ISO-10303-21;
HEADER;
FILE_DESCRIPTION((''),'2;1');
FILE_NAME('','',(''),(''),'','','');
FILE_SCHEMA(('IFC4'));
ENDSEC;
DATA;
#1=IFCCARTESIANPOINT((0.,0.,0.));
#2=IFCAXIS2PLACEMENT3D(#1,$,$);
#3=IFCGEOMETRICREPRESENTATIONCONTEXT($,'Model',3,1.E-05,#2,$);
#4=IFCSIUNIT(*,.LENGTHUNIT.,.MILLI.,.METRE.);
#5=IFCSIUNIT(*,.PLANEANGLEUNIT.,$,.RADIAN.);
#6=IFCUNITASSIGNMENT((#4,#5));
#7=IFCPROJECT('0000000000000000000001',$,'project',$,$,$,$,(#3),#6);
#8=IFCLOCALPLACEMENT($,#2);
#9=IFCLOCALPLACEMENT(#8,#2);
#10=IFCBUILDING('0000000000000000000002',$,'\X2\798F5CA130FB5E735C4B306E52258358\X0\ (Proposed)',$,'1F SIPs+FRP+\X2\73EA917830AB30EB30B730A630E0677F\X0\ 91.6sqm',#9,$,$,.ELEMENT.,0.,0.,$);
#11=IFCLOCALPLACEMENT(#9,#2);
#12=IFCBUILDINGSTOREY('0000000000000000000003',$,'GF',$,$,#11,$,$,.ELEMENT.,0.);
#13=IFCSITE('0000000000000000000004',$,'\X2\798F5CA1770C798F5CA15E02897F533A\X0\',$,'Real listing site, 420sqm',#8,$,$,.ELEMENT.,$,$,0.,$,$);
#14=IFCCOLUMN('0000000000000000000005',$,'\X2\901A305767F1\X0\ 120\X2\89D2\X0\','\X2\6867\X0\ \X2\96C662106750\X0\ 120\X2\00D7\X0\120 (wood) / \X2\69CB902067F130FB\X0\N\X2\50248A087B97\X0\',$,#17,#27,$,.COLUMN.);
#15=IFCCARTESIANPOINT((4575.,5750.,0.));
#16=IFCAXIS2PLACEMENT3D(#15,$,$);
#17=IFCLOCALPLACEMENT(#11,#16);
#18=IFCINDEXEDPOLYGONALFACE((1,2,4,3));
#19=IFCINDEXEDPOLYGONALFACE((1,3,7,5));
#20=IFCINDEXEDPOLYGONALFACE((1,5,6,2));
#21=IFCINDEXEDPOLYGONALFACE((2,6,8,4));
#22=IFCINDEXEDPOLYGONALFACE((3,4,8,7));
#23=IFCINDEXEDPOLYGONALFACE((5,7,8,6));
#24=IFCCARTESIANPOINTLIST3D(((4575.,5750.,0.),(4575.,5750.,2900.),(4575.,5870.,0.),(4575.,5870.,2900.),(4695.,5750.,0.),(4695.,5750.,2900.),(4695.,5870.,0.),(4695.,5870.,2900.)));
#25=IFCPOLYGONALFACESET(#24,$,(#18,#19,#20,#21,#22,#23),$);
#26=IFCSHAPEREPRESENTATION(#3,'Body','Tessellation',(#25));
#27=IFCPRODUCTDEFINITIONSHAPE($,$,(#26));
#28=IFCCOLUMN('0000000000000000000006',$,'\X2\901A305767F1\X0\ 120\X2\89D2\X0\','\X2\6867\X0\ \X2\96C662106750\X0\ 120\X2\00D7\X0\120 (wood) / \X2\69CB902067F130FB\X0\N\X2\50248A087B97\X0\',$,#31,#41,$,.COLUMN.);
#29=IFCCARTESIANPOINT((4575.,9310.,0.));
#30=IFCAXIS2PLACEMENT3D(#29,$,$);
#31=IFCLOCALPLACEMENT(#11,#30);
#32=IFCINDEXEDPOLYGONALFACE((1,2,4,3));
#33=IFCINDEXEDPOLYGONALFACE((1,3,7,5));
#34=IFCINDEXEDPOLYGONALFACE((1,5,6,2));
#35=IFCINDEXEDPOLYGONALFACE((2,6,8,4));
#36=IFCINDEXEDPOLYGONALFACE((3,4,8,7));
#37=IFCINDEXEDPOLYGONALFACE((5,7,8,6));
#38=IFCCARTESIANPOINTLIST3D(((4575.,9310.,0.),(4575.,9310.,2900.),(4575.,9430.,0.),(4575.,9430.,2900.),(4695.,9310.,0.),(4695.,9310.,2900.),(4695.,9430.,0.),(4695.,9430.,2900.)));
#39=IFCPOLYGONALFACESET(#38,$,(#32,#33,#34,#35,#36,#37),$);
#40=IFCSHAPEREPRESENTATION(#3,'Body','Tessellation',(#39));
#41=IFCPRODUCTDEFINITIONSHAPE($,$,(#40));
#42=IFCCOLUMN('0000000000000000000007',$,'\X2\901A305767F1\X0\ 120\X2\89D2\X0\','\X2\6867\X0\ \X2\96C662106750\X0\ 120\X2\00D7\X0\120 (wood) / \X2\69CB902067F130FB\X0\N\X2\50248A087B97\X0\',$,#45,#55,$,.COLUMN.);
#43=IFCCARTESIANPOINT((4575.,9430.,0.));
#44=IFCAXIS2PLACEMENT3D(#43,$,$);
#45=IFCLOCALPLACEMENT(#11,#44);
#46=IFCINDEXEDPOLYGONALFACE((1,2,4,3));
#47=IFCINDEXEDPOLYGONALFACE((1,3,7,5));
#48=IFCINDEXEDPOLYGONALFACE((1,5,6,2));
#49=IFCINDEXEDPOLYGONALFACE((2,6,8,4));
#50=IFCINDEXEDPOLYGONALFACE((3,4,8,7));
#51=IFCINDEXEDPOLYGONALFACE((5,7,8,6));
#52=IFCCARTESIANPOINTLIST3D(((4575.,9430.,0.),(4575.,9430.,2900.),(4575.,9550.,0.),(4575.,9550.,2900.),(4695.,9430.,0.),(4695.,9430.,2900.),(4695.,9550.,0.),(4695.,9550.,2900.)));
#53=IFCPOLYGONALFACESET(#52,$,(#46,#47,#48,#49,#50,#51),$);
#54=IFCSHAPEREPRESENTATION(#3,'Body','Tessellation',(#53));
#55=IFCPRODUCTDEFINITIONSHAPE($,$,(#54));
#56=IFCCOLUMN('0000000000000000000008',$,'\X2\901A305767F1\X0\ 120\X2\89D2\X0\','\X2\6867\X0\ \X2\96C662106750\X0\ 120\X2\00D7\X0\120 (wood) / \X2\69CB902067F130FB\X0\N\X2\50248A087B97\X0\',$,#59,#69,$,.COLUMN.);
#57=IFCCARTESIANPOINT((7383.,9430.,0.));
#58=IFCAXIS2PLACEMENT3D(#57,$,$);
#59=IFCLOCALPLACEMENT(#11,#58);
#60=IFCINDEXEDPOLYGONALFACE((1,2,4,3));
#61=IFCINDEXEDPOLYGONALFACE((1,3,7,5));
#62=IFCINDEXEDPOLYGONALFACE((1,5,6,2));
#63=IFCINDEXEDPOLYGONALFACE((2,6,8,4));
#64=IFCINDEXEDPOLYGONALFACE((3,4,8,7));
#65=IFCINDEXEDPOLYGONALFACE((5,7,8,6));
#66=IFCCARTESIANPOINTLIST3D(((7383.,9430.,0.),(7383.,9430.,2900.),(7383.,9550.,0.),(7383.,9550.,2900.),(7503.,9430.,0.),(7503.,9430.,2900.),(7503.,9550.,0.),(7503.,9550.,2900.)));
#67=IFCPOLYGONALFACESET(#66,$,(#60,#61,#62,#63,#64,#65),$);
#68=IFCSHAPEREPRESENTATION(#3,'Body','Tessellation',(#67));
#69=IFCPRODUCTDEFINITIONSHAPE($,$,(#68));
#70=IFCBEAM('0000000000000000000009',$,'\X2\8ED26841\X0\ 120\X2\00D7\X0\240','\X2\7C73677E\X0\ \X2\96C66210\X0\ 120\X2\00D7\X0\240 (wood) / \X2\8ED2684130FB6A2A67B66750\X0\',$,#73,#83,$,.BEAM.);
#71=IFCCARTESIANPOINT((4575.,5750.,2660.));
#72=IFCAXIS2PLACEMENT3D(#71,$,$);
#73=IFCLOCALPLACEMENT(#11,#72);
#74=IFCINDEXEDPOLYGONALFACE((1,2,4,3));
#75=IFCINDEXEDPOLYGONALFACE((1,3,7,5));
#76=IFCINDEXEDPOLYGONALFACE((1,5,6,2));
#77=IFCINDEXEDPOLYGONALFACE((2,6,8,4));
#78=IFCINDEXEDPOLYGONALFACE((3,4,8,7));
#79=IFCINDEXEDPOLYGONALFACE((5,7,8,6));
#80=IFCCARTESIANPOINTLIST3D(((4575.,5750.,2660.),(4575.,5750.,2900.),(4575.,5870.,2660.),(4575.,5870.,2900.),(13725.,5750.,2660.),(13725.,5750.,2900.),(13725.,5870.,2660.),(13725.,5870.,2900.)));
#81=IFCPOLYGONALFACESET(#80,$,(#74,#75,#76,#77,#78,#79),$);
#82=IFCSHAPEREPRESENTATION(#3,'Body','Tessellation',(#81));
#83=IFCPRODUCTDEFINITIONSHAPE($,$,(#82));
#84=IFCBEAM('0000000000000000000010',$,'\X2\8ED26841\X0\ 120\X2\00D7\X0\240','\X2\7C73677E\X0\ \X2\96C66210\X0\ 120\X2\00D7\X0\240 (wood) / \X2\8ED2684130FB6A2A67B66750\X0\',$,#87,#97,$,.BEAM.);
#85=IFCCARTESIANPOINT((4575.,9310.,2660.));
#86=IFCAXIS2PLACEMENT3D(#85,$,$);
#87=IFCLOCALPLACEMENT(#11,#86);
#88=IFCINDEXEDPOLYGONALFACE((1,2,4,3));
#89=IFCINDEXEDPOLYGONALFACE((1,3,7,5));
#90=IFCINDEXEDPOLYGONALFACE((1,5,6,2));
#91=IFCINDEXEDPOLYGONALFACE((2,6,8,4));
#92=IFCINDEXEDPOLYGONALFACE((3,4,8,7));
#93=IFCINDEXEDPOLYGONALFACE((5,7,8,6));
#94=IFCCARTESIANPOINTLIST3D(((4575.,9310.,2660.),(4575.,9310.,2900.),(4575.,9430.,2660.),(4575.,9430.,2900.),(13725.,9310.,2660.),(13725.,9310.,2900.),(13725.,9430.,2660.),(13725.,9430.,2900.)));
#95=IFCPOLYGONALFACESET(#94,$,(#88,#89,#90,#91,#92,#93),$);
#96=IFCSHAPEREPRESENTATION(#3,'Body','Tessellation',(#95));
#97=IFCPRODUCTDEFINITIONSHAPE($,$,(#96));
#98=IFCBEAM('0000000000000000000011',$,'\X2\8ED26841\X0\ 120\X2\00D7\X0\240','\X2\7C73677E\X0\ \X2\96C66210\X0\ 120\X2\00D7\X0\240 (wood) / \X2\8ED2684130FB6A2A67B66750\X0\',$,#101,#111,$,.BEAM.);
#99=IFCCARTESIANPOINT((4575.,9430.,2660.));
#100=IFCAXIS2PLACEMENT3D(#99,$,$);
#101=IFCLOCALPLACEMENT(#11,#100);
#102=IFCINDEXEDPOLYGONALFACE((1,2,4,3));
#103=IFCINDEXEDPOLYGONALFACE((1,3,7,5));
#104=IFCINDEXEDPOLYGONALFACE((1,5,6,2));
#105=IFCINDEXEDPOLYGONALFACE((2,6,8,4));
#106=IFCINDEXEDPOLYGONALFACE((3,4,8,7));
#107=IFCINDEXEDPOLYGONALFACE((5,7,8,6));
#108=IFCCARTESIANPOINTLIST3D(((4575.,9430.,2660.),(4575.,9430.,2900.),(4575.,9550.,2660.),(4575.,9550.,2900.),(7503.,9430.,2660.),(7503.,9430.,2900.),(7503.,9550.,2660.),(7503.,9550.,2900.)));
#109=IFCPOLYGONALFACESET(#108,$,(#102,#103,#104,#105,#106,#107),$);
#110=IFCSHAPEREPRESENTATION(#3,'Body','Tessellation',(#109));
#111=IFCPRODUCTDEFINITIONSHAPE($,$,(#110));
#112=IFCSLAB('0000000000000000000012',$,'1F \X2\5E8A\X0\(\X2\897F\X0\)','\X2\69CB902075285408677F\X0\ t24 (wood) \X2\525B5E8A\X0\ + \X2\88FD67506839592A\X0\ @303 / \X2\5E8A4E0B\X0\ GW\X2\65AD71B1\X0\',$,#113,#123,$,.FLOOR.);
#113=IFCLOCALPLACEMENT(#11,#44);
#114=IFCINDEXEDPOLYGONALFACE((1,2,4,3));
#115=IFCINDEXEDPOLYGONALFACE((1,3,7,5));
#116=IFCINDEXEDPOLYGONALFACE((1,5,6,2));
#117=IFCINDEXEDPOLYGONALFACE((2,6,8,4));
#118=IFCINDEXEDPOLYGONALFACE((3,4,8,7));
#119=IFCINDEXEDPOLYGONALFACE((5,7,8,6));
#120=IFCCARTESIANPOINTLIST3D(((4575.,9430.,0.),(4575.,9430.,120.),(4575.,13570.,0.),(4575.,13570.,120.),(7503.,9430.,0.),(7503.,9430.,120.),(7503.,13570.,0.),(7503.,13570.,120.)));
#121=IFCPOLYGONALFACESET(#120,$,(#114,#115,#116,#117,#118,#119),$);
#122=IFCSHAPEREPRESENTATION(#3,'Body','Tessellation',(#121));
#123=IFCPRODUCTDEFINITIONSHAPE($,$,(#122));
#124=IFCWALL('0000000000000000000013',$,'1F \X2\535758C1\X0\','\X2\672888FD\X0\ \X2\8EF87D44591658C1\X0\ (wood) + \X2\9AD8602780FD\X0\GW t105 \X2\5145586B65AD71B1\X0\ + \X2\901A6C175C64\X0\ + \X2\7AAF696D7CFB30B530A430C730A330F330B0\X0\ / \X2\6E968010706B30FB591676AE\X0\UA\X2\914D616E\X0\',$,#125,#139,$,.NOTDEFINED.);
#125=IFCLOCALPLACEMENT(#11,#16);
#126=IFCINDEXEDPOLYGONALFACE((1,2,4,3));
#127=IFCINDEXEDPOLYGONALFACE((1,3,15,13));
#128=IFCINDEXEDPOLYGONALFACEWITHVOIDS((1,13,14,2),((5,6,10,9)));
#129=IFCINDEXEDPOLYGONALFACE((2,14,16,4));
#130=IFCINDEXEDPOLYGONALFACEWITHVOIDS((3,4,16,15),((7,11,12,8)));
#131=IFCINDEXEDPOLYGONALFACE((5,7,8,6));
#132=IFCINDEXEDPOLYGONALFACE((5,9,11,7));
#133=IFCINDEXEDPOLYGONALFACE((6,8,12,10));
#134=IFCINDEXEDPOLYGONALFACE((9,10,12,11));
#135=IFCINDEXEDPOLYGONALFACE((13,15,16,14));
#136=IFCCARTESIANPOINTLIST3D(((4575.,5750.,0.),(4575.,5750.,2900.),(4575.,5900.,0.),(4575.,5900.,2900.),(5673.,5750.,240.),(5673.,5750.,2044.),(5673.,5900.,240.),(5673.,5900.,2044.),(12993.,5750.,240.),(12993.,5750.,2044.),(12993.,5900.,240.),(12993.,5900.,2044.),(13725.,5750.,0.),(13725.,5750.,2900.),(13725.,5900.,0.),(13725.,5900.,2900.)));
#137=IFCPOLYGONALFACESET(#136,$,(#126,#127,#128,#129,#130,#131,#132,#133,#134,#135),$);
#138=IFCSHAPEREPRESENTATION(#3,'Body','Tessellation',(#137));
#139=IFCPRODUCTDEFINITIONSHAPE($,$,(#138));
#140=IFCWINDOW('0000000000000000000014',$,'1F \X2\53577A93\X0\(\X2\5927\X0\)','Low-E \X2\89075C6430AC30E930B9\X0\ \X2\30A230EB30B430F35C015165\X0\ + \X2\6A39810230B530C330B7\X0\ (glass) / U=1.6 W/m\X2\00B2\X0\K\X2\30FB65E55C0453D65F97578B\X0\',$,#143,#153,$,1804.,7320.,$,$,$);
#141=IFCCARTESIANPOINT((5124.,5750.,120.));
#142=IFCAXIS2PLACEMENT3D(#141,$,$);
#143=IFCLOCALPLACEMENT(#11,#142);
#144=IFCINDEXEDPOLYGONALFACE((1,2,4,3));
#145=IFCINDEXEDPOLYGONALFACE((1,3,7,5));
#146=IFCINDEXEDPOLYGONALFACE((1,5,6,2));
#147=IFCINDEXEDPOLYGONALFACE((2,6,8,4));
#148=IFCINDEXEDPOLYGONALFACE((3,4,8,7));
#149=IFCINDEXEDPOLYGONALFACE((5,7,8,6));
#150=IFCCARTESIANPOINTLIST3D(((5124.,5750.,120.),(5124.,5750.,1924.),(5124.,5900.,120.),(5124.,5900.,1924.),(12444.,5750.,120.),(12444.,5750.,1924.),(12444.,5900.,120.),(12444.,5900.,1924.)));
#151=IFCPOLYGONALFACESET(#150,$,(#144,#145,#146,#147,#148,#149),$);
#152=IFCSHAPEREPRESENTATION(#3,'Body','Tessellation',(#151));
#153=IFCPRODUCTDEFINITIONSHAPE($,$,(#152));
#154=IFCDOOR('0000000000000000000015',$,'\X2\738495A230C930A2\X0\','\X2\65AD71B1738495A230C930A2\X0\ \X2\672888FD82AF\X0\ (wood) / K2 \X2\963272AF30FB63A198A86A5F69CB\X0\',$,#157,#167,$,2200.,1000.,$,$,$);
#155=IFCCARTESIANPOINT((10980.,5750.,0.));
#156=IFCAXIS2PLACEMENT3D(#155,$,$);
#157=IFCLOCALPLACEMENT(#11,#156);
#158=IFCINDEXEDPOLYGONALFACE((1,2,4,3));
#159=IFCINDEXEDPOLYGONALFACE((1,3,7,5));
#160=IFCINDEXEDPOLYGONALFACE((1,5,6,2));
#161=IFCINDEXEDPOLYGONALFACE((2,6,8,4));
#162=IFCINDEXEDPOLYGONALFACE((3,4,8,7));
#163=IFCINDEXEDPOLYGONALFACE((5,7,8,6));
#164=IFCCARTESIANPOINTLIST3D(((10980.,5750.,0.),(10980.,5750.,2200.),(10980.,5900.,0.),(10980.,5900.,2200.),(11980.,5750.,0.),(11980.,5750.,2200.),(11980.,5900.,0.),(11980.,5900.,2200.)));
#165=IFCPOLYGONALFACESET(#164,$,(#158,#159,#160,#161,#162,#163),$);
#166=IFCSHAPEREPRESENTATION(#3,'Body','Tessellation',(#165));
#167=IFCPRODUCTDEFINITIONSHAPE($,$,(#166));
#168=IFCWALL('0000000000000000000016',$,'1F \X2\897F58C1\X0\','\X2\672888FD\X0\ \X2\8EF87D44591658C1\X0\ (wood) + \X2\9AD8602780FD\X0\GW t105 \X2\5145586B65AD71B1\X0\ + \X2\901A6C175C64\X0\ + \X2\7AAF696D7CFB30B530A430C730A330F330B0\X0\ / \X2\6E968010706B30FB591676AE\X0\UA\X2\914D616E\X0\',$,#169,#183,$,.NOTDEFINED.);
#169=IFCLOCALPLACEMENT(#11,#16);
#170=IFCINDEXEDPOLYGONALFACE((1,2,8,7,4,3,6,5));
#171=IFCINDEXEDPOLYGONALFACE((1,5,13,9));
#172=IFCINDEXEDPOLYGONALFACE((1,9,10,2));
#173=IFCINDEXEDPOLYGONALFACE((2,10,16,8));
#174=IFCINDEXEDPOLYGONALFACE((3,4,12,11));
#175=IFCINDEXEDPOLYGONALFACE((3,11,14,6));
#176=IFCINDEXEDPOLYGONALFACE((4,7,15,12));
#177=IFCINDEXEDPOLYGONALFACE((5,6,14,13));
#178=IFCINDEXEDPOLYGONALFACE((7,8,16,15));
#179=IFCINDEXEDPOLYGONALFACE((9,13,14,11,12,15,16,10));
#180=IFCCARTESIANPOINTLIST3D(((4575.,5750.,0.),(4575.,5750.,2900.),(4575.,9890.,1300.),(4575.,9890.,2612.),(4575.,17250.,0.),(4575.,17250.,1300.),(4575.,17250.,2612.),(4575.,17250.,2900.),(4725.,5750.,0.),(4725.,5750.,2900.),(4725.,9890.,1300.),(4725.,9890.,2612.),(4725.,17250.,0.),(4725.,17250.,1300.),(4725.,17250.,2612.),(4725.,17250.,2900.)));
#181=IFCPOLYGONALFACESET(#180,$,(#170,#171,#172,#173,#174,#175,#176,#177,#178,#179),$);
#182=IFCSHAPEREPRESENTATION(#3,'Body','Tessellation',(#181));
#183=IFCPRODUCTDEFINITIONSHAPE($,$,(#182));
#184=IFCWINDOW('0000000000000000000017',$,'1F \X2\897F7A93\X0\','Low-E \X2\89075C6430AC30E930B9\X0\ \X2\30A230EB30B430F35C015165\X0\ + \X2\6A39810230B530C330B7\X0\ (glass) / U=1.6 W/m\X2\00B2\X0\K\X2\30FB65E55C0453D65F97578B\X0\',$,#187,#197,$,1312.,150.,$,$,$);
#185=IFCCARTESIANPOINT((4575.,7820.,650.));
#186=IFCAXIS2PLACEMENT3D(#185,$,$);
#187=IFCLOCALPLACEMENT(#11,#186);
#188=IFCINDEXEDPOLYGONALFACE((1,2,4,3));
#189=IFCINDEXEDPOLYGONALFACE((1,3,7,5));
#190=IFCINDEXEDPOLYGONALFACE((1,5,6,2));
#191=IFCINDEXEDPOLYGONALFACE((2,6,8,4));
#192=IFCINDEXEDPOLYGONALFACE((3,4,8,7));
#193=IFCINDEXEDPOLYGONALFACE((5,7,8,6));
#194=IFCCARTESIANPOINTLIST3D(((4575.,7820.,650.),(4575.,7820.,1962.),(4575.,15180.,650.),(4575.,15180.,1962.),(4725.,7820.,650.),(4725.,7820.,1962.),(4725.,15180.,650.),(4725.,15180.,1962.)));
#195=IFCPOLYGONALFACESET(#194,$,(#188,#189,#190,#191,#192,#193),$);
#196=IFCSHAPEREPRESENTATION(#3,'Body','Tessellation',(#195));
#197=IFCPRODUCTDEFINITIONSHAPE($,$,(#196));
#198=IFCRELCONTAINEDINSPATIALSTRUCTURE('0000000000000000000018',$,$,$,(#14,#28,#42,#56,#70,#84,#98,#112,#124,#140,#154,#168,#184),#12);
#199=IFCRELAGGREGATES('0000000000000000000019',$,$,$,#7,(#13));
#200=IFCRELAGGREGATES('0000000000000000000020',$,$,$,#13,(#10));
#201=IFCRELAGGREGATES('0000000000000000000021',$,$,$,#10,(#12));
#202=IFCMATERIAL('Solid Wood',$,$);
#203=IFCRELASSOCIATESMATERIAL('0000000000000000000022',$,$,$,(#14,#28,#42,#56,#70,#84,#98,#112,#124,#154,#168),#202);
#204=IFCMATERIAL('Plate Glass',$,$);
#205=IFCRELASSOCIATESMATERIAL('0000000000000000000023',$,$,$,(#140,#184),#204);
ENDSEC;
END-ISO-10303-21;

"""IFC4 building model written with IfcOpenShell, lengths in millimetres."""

from ifc_helpers import new_model, si_unit, frame, frame_2d, origin, place, context, project, spatial, rectangle, extrude, material, element, fill, save


model = new_model("IFC4")

# Units and contexts
model_context = context("Model", 3, precision=1e-05, world=origin())
ifc_project = project(units=[si_unit("LENGTHUNIT", "METRE", prefix="MILLI"), si_unit("PLANEANGLEUNIT", "RADIAN")], contexts=[model_context])

# Site, building, storey
site_placement = place(None, origin())
site = spatial("IfcSite", under=ifc_project, at=site_placement, Name="福岡県福岡市西区", ObjectType="Real listing site, 420sqm", CompositionType="ELEMENT", RefElevation=0.0)
building_placement = place(site_placement, origin())
building = spatial("IfcBuilding", under=site, at=building_placement, Name="福岡・平屋の別荘 (Proposed)", ObjectType="1F SIPs+FRP+珪酸カルシウム板 91.6sqm", CompositionType="ELEMENT", ElevationOfRefHeight=0.0, ElevationOfTerrain=0.0)
storey_placement = place(building_placement, origin())
storey = spatial("IfcBuildingStorey", under=building, at=storey_placement, Name="GF", CompositionType="ELEMENT", Elevation=0.0)

# Columns
ifc_material_1 = material(Name="Solid Wood")
column_1_placement = place(storey_placement, frame((4575.0, 5750.0, 0.0)))
element("IfcColumn", 1, at=column_1_placement, inside=storey, material=ifc_material_1, Name="通し柱 120角", Description="桧 集成材 120×120 (wood) / 構造柱・N値計算", PredefinedType="COLUMN", context=model_context, shape_type="SweptSolid", body=[
    extrude(rectangle(XDim=120.0, YDim=120.0, at=frame_2d((60.0, 60.0))), frame((4575.0, 5750.0, 0.0)), (0.0, 0.0, 1.0), 2900.0),
])
column_2_placement = place(storey_placement, frame((4575.0, 9310.0, 0.0)))
element("IfcColumn", 2, at=column_2_placement, inside=storey, material=ifc_material_1, Name="通し柱 120角", Description="桧 集成材 120×120 (wood) / 構造柱・N値計算", PredefinedType="COLUMN", context=model_context, shape_type="SweptSolid", body=[
    extrude(rectangle(XDim=120.0, YDim=120.0, at=frame_2d((60.0, 60.0))), frame((4575.0, 9310.0, 0.0)), (0.0, 0.0, 1.0), 2900.0),
])
column_3_placement = place(storey_placement, frame((4575.0, 9430.0, 0.0)))
element("IfcColumn", 3, at=column_3_placement, inside=storey, material=ifc_material_1, Name="通し柱 120角", Description="桧 集成材 120×120 (wood) / 構造柱・N値計算", PredefinedType="COLUMN", context=model_context, shape_type="SweptSolid", body=[
    extrude(rectangle(XDim=120.0, YDim=120.0, at=frame_2d((60.0, 60.0))), frame((4575.0, 9430.0, 0.0)), (0.0, 0.0, 1.0), 2900.0),
])
column_4_placement = place(storey_placement, frame((7383.0, 9430.0, 0.0)))
element("IfcColumn", 4, at=column_4_placement, inside=storey, material=ifc_material_1, Name="通し柱 120角", Description="桧 集成材 120×120 (wood) / 構造柱・N値計算", PredefinedType="COLUMN", context=model_context, shape_type="SweptSolid", body=[
    extrude(rectangle(XDim=120.0, YDim=120.0, at=frame_2d((60.0, 60.0))), frame((7383.0, 9430.0, 0.0)), (0.0, 0.0, 1.0), 2900.0),
])

# Beams
beam_1_placement = place(storey_placement, frame((4575.0, 5750.0, 2660.0)))
element("IfcBeam", 5, at=beam_1_placement, inside=storey, material=ifc_material_1, Name="軒桁 120×240", Description="米松 集成 120×240 (wood) / 軒桁・横架材", PredefinedType="BEAM", context=model_context, shape_type="SweptSolid", body=[
    extrude(rectangle(XDim=9150.0, YDim=120.0, at=frame_2d((4575.0, 60.0))), frame((4575.0, 5750.0, 2660.0)), (0.0, 0.0, 1.0), 240.0),
])
beam_2_placement = place(storey_placement, frame((4575.0, 9310.0, 2660.0)))
element("IfcBeam", 6, at=beam_2_placement, inside=storey, material=ifc_material_1, Name="軒桁 120×240", Description="米松 集成 120×240 (wood) / 軒桁・横架材", PredefinedType="BEAM", context=model_context, shape_type="SweptSolid", body=[
    extrude(rectangle(XDim=9150.0, YDim=120.0, at=frame_2d((4575.0, 60.0))), frame((4575.0, 9310.0, 2660.0)), (0.0, 0.0, 1.0), 240.0),
])
beam_3_placement = place(storey_placement, frame((4575.0, 9430.0, 2660.0)))
element("IfcBeam", 7, at=beam_3_placement, inside=storey, material=ifc_material_1, Name="軒桁 120×240", Description="米松 集成 120×240 (wood) / 軒桁・横架材", PredefinedType="BEAM", context=model_context, shape_type="SweptSolid", body=[
    extrude(rectangle(XDim=2928.0, YDim=120.0, at=frame_2d((1464.0, 60.0))), frame((4575.0, 9430.0, 2660.0)), (0.0, 0.0, 1.0), 240.0),
])

# Slab
slab_1_placement = place(storey_placement, frame((4575.0, 9430.0, 0.0)))
element("IfcSlab", 8, at=slab_1_placement, inside=storey, material=ifc_material_1, Name="1F 床(西)", Description="構造用合板 t24 (wood) 剛床 + 製材根太 @303 / 床下 GW断熱", PredefinedType="FLOOR", context=model_context, shape_type="SweptSolid", body=[
    extrude(rectangle(XDim=2928.0, YDim=4140.0, at=frame_2d((1464.0, 2070.0))), frame((4575.0, 9430.0, 0.0)), (0.0, 0.0, 1.0), 120.0),
])

# Wall, openings, window, door
wall_1_placement = place(storey_placement, frame((4575.0, 5750.0, 0.0)))
wall_1 = element("IfcWall", 9, at=wall_1_placement, inside=storey, material=ifc_material_1, Name="1F 南壁", Description="木製 軸組外壁 (wood) + 高性能GW t105 充填断熱 + 通気層 + 窯業系サイディング / 準耐火・外皮UA配慮", PredefinedType="NOTDEFINED", context=model_context, shape_type="SweptSolid", body=[
    extrude(rectangle(XDim=9150.0, YDim=150.0, at=frame_2d((4575.0, 75.0))), frame((4575.0, 5750.0, 0.0)), (0.0, 0.0, 1.0), 2900.0),
])
opening_1_placement = place(storey_placement, frame((5124.0, 5750.0, 120.0)))
opening_1 = element("IfcOpeningElement", 10, at=opening_1_placement, cuts=wall_1, PredefinedType="NOTDEFINED", context=model_context, shape_type="SweptSolid", body=[
    extrude(rectangle(XDim=7320.0, YDim=150.0, at=frame_2d((3660.0, 75.0))), frame((5124.0, 5750.0, 120.0)), (0.0, 0.0, 1.0), 1804.0),
])
opening_2_placement = place(storey_placement, frame((10980.0, 5750.0, 0.0)))
opening_2 = element("IfcOpeningElement", 11, at=opening_2_placement, cuts=wall_1, PredefinedType="NOTDEFINED", context=model_context, shape_type="SweptSolid", body=[
    extrude(rectangle(XDim=1000.0, YDim=150.0, at=frame_2d((500.0, 75.0))), frame((10980.0, 5750.0, 0.0)), (0.0, 0.0, 1.0), 2200.0),
])
ifc_material_2 = material(Name="Plate Glass")
window_1_placement = place(storey_placement, frame((5124.0, 5750.0, 120.0)))
window_1 = element("IfcWindow", 12, at=window_1_placement, inside=storey, material=ifc_material_2, Name="1F 南窓(大)", Description="Low-E 複層ガラス アルゴン封入 + 樹脂サッシ (glass) / U=1.6 W/m²K・日射取得型", OverallHeight=1804.0, OverallWidth=7320.0, context=model_context, shape_type="SweptSolid", body=[
    extrude(rectangle(XDim=7320.0, YDim=150.0, at=frame_2d((3660.0, 75.0))), frame((5124.0, 5750.0, 120.0)), (0.0, 0.0, 1.0), 1804.0),
])
fill(opening_1, window_1)
door_placement = place(storey_placement, frame((10980.0, 5750.0, 0.0)))
door = element("IfcDoor", 13, at=door_placement, inside=storey, material=ifc_material_1, Name="玄関ドア", Description="断熱玄関ドア 木製芯 (wood) / K2 防犯・採風機構", OverallHeight=2200.0, OverallWidth=1000.0, context=model_context, shape_type="SweptSolid", body=[
    extrude(rectangle(XDim=1000.0, YDim=150.0, at=frame_2d((500.0, 75.0))), frame((10980.0, 5750.0, 0.0)), (0.0, 0.0, 1.0), 2200.0),
])
fill(opening_2, door)

# Wall, opening, window
wall_2_placement = place(storey_placement, frame((4575.0, 5750.0, 0.0)))
wall_2 = element("IfcWall", 14, at=wall_2_placement, inside=storey, material=ifc_material_1, Name="1F 西壁", Description="木製 軸組外壁 (wood) + 高性能GW t105 充填断熱 + 通気層 + 窯業系サイディング / 準耐火・外皮UA配慮", PredefinedType="NOTDEFINED", context=model_context, shape_type="SweptSolid", body=[
    extrude(rectangle(XDim=150.0, YDim=11500.0, at=frame_2d((75.0, 5750.0))), frame((4575.0, 5750.0, 0.0)), (0.0, 0.0, 1.0), 2900.0),
])
opening_3_placement = place(storey_placement, frame((4575.0, 7820.0, 650.0)))
opening_3 = element("IfcOpeningElement", 15, at=opening_3_placement, cuts=wall_2, PredefinedType="NOTDEFINED", context=model_context, shape_type="SweptSolid", body=[
    extrude(rectangle(XDim=150.0, YDim=7360.0, at=frame_2d((75.0, 3680.0))), frame((4575.0, 7820.0, 650.0)), (0.0, 0.0, 1.0), 1312.0),
])
window_2_placement = place(storey_placement, frame((4575.0, 7820.0, 650.0)))
window_2 = element("IfcWindow", 16, at=window_2_placement, inside=storey, material=ifc_material_2, Name="1F 西窓", Description="Low-E 複層ガラス アルゴン封入 + 樹脂サッシ (glass) / U=1.6 W/m²K・日射取得型", OverallHeight=1312.0, OverallWidth=150.0, context=model_context, shape_type="SweptSolid", body=[
    extrude(rectangle(XDim=150.0, YDim=7360.0, at=frame_2d((75.0, 3680.0))), frame((4575.0, 7820.0, 650.0)), (0.0, 0.0, 1.0), 1312.0),
])
fill(opening_3, window_2)

save(model, "model.ifc")
